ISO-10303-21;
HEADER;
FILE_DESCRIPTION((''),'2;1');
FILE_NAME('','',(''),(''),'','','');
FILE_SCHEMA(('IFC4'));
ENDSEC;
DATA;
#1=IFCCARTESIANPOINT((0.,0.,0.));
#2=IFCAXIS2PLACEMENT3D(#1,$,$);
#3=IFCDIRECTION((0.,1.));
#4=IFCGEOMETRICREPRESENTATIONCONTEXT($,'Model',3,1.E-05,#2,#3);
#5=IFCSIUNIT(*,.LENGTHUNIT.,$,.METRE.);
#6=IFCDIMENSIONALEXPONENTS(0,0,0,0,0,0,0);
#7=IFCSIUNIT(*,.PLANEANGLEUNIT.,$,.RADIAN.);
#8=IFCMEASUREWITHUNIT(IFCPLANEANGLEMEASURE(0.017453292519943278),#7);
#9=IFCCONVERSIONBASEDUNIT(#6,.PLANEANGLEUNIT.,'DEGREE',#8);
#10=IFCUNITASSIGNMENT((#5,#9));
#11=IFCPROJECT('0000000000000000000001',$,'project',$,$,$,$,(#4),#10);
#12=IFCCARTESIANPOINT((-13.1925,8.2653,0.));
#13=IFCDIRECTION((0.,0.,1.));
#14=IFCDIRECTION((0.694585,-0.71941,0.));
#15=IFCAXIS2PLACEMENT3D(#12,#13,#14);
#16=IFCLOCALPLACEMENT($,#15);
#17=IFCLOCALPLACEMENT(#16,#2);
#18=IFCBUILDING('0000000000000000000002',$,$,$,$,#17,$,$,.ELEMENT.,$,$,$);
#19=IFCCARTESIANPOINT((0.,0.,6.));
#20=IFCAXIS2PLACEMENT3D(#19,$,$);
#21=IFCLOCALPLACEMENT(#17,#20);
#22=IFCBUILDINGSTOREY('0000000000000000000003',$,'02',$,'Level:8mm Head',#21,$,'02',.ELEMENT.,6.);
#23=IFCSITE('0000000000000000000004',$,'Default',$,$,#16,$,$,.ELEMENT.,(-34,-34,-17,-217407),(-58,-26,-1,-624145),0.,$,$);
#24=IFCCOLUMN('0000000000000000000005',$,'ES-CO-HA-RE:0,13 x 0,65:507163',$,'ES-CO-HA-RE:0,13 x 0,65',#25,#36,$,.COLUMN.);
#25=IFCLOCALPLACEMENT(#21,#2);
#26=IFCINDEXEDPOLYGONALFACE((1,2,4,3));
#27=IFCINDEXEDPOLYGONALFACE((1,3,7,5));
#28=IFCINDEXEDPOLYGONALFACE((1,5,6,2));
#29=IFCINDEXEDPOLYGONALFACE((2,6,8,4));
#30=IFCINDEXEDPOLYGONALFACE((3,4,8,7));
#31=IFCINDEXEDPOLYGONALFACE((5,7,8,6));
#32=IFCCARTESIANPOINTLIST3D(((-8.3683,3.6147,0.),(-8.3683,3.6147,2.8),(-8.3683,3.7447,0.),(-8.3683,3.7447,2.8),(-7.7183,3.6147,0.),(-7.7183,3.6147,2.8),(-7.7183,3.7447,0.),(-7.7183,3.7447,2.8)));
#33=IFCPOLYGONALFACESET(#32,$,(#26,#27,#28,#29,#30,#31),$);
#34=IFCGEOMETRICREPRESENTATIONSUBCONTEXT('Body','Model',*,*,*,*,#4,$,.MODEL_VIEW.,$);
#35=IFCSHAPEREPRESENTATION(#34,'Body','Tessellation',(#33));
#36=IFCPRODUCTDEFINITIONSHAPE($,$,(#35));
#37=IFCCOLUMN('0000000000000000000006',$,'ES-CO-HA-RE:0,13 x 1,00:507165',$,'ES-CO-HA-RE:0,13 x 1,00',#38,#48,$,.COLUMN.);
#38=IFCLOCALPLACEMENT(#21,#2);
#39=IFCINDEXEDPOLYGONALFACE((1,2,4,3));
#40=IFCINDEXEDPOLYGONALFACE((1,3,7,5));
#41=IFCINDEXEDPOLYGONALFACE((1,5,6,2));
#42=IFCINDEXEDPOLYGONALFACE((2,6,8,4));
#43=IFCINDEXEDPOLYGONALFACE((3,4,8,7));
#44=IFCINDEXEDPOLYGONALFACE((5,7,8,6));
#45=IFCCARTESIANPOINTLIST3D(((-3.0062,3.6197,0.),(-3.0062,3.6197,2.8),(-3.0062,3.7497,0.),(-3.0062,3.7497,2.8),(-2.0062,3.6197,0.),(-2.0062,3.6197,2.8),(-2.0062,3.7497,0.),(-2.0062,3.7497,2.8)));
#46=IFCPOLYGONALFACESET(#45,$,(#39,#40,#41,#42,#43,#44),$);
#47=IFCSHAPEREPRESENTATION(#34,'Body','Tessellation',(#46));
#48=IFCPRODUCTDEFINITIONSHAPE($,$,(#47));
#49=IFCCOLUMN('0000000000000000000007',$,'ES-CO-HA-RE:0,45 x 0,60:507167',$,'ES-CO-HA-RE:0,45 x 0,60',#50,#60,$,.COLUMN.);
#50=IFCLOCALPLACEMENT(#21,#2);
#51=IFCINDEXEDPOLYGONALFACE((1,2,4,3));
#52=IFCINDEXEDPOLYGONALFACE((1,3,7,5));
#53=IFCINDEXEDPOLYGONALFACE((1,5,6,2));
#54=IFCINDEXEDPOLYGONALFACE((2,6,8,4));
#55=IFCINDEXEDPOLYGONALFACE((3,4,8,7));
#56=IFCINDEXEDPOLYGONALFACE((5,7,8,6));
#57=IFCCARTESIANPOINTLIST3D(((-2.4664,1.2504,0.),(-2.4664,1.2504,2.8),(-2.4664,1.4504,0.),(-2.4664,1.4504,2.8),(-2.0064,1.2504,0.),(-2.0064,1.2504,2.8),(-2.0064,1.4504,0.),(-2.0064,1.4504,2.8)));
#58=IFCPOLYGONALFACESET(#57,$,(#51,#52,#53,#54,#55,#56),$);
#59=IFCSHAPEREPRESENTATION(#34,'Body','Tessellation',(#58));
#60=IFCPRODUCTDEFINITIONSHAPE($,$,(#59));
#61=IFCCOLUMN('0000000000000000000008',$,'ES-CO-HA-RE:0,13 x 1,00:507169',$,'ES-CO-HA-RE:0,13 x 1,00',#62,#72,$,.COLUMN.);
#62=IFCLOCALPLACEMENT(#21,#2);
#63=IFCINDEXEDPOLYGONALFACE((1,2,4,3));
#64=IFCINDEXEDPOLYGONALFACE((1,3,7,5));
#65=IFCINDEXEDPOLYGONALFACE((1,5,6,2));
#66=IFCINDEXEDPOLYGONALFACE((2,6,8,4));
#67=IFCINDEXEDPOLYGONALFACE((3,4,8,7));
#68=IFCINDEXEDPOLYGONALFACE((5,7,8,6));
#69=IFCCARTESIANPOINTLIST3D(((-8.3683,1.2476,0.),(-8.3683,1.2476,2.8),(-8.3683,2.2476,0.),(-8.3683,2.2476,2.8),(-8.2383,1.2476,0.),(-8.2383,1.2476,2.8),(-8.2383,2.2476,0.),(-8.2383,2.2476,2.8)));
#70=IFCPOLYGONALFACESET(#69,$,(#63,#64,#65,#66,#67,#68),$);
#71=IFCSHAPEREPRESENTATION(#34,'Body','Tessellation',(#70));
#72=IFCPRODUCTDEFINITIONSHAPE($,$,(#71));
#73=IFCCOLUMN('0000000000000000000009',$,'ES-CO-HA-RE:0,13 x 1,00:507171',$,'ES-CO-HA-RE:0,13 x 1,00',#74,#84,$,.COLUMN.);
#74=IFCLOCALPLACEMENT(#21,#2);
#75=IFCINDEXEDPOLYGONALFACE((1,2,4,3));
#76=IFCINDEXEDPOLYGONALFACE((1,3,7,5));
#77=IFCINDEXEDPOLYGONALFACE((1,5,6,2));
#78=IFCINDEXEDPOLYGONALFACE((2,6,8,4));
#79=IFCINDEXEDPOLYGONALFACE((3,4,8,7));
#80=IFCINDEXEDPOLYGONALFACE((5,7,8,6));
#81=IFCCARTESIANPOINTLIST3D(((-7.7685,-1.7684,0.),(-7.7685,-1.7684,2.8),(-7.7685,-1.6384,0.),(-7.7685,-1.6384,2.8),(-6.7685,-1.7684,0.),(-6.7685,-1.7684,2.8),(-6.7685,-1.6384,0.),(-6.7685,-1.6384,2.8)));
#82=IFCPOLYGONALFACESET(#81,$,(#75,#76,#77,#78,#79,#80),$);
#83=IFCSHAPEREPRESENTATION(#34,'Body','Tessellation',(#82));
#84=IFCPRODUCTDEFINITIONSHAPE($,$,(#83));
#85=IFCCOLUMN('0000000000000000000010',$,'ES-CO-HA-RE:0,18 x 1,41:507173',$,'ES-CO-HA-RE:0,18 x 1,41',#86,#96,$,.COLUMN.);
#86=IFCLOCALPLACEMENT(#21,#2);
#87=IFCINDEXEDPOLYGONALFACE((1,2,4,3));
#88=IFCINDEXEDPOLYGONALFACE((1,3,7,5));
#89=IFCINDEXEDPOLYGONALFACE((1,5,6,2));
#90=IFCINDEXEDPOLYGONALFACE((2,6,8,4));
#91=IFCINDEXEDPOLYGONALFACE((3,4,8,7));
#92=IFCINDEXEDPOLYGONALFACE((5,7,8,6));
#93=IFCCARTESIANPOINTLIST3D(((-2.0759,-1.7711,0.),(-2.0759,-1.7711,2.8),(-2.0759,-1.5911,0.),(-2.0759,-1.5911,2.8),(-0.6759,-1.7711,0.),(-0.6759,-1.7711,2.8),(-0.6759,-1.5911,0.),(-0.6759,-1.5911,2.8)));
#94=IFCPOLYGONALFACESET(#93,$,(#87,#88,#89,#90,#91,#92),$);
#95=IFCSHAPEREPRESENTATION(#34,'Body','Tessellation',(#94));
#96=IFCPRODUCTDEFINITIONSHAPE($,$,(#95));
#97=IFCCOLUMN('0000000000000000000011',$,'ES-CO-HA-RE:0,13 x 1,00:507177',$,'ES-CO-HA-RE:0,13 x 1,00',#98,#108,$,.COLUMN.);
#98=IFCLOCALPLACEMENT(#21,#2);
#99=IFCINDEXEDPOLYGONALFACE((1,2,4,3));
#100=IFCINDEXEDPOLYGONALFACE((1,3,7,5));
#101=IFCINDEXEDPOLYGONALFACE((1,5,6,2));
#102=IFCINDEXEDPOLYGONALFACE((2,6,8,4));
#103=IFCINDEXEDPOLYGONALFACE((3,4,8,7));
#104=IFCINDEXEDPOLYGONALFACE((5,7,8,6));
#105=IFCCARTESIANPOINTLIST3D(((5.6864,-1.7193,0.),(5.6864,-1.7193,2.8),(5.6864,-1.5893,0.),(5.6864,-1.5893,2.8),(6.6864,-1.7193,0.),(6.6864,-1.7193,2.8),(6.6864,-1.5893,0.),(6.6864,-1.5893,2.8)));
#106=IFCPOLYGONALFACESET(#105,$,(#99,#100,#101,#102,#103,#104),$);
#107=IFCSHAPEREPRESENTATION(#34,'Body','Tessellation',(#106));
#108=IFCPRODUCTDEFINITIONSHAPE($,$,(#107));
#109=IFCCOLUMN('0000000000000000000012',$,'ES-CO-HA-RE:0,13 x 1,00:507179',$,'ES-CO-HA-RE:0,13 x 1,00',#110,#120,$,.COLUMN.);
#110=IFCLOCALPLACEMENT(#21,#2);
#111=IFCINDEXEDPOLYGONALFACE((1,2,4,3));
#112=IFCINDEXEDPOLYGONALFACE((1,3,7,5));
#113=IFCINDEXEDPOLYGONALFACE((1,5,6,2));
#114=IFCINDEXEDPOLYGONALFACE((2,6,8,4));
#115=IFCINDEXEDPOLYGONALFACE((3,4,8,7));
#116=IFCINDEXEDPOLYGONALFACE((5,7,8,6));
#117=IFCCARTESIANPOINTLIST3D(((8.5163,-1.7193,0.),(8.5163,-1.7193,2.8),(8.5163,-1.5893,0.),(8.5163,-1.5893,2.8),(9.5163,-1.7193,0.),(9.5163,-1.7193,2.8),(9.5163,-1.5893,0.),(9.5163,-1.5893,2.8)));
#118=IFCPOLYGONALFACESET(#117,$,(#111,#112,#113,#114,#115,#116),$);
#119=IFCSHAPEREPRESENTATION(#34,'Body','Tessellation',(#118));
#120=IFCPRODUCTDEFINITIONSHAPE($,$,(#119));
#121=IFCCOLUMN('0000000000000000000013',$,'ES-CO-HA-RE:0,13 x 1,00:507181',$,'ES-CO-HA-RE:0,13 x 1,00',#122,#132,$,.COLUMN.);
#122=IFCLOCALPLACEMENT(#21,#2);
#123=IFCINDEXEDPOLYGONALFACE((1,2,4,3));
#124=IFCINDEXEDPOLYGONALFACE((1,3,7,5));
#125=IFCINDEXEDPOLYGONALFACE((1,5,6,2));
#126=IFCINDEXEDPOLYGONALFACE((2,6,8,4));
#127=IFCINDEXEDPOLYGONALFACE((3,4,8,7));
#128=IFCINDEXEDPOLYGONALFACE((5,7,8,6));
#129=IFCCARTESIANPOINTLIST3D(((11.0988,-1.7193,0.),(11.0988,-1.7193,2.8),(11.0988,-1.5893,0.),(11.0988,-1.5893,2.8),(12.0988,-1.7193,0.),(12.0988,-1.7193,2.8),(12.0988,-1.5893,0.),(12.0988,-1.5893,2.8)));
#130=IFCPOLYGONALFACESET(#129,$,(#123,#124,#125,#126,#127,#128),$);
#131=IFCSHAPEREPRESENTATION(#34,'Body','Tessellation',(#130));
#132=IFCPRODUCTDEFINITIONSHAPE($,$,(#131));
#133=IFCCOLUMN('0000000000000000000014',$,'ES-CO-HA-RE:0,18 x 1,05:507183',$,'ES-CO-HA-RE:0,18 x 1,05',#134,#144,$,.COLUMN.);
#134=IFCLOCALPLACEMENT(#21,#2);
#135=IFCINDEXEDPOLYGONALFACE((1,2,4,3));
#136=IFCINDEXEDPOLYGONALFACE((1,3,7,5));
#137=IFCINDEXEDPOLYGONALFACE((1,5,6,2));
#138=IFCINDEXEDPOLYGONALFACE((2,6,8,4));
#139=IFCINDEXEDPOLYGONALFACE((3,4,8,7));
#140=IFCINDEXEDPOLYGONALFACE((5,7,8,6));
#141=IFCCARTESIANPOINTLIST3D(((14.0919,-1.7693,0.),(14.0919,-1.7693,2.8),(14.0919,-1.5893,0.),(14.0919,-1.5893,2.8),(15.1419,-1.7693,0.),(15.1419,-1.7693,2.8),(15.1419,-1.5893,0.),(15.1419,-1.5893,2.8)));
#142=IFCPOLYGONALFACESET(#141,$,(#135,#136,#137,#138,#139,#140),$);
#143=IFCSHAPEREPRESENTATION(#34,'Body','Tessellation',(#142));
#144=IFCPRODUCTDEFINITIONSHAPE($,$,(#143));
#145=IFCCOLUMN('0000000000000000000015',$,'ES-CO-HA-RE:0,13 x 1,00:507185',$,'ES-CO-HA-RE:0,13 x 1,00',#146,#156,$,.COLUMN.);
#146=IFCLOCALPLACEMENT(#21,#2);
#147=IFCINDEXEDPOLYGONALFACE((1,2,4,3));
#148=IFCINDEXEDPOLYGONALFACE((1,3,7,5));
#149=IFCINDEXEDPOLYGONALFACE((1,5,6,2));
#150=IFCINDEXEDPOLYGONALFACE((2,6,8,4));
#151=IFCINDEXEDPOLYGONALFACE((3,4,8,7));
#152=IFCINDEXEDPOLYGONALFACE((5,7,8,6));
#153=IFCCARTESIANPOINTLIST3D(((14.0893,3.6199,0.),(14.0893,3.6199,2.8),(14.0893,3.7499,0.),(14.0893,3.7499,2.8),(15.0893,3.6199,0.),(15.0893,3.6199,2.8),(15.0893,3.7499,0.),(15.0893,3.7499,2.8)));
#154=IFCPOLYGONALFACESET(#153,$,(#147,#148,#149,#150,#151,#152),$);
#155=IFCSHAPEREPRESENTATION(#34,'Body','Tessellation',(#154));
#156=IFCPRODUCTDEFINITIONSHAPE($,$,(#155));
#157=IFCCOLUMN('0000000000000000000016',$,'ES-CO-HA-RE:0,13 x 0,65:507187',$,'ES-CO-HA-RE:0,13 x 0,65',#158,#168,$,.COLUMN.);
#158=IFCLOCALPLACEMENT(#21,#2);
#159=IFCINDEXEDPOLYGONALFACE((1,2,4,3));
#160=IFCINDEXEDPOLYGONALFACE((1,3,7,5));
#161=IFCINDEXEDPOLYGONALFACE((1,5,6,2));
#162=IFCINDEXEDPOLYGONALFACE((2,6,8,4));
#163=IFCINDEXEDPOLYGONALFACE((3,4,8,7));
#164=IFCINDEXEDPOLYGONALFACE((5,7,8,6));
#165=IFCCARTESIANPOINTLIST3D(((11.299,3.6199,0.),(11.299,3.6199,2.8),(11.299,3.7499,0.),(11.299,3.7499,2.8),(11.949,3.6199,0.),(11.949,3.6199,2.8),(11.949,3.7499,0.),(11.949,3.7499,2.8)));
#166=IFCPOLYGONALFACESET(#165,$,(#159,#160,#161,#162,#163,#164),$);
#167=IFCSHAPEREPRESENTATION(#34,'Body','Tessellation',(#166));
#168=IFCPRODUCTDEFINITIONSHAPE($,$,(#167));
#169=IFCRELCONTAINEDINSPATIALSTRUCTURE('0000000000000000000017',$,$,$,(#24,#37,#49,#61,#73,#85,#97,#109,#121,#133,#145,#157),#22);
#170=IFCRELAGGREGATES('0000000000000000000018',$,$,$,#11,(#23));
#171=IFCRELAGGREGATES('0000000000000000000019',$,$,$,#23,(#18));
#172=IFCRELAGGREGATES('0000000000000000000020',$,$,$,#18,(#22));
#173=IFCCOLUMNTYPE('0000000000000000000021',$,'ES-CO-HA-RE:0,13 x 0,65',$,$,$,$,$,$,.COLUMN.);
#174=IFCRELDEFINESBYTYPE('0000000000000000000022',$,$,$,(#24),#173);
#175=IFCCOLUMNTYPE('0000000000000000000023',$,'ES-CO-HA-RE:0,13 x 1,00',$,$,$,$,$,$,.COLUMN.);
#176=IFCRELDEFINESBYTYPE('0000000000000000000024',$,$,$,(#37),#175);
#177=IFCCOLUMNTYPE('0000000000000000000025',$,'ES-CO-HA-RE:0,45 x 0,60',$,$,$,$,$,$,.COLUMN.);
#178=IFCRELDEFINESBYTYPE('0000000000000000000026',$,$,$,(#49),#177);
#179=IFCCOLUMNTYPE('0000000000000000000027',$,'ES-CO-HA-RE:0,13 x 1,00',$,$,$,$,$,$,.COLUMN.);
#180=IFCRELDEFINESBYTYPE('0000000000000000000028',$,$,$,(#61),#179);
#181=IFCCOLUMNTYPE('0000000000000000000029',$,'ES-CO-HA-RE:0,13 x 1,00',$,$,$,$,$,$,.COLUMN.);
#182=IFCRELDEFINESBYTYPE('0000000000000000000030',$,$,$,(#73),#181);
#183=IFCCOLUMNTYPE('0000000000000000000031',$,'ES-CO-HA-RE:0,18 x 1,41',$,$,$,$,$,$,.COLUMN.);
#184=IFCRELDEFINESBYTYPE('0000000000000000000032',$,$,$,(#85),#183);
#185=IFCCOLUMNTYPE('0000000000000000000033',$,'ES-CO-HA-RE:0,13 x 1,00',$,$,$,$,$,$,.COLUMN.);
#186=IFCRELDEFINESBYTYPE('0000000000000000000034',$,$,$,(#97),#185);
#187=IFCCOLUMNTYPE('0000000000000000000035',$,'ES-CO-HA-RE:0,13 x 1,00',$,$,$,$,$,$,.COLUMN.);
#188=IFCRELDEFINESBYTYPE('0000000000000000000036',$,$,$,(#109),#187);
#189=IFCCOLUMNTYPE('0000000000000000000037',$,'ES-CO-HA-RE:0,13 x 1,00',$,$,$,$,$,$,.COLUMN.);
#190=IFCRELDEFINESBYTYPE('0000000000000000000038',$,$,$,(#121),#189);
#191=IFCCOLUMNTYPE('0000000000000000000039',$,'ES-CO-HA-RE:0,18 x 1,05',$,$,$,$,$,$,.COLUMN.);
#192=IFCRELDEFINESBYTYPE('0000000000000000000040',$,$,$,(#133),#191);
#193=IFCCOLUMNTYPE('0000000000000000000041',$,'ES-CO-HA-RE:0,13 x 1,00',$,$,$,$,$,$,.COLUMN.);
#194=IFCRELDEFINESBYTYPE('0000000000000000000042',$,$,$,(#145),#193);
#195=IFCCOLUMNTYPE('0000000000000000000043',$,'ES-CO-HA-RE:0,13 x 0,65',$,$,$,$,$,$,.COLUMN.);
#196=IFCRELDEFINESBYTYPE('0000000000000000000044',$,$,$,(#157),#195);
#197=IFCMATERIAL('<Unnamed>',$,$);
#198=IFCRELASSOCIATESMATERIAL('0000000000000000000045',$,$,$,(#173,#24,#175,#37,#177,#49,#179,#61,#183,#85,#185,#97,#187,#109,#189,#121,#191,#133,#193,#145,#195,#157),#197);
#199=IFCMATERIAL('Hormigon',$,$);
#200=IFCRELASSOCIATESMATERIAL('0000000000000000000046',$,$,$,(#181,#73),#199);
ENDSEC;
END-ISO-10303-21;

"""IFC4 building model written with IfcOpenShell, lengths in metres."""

from ifc_helpers import new_model, entity, si_unit, converted_unit, direction, frame, origin, place, context, subcontext, project, spatial, indexed_curve, outline, extrude, source, transform, mapped, material, type_object, type_shapes, element, save


model = new_model("IFC4")

# Units and contexts
model_context = context("Model", 3, precision=1e-05, world=origin(), true_north=direction((0.0, 1.0)))
body_context = subcontext(model_context, "Body", "Model", "MODEL_VIEW")
ifc_project = project(units=[si_unit("LENGTHUNIT", "METRE"), converted_unit("PLANEANGLEUNIT", "DEGREE", entity("IfcPlaneAngleMeasure", 0.017453292519943278), si_unit("PLANEANGLEUNIT", "RADIAN"), dimensions=[0, 0, 0, 0, 0, 0, 0])], contexts=[model_context])

# Site, building, storey
site_placement = place(None, frame((-13.1925, 8.2653, 0.0), z_axis=(0.0, 0.0, 1.0), x_axis=(0.694585, -0.71941, 0.0)))
site = spatial("IfcSite", under=ifc_project, at=site_placement, Name="Default", CompositionType="ELEMENT", RefLatitude=(-34, -34, -17, -217407), RefLongitude=(-58, -26, -1, -624145), RefElevation=0.0)
building_placement = place(site_placement, origin())
building = spatial("IfcBuilding", under=site, at=building_placement, CompositionType="ELEMENT")
storey_placement = place(building_placement, frame((0.0, 0.0, 6.0)))
storey = spatial("IfcBuildingStorey", under=building, at=storey_placement, Name="02", ObjectType="Level:8mm Head", LongName="02", CompositionType="ELEMENT", Elevation=6.0)

# Columns
ifc_material_1 = material(Name="<Unnamed>")
column_type_1 = type_object("IfcColumnType", Name="ES-CO-HA-RE:0,13 x 0,65", PredefinedType="COLUMN", material=ifc_material_1)
shared_shape_1 = source(origin(), body_context, "Body", "SweptSolid", [
    extrude(outline(indexed_curve([(-0.325, -0.065), (0.325, -0.065), (0.325, 0.065), (-0.325, 0.065), (-0.325, -0.065)], self_intersect=False)), frame((-8.0433, 3.6797, 6.0), z_axis=(0.0, 0.0, 1.0), x_axis=(-1.0, 0.0, 0.0)), (0.0, 0.0, 1.0), 2.8),
])
type_shapes(column_type_1, [shared_shape_1])
column_1_placement = place(storey_placement, frame((0.0, 0.0, -6.0)))
element("IfcColumn", 1, at=column_1_placement, inside=storey, type_object=column_type_1, material=ifc_material_1, Name="ES-CO-HA-RE:0,13 x 0,65:507163", ObjectType="ES-CO-HA-RE:0,13 x 0,65", PredefinedType="COLUMN", context=body_context, shape_type="MappedRepresentation", body=[
    mapped(shared_shape_1, transform((0.0, 0.0, 0.0), scale=1.0)),
])
column_type_2 = type_object("IfcColumnType", Name="ES-CO-HA-RE:0,13 x 1,00", PredefinedType="COLUMN", material=ifc_material_1)
shared_shape_2 = source(origin(), body_context, "Body", "SweptSolid", [
    extrude(outline(indexed_curve([(-0.5, -0.065), (0.5, -0.065), (0.5, 0.065), (-0.5, 0.065), (-0.5, -0.065)], self_intersect=False)), frame((-2.5062, 3.6847, 6.0), z_axis=(0.0, 0.0, 1.0), x_axis=(-1.0, 0.0, 0.0)), (0.0, 0.0, 1.0), 2.8),
])
type_shapes(column_type_2, [shared_shape_2])
column_2_placement = place(storey_placement, frame((0.0, 0.0, -6.0)))
element("IfcColumn", 2, at=column_2_placement, inside=storey, type_object=column_type_2, material=ifc_material_1, Name="ES-CO-HA-RE:0,13 x 1,00:507165", ObjectType="ES-CO-HA-RE:0,13 x 1,00", PredefinedType="COLUMN", context=body_context, shape_type="MappedRepresentation", body=[
    mapped(shared_shape_2, transform((0.0, 0.0, 0.0), scale=1.0)),
])
column_type_3 = type_object("IfcColumnType", Name="ES-CO-HA-RE:0,45 x 0,60", PredefinedType="COLUMN", material=ifc_material_1)
shared_shape_3 = source(origin(), body_context, "Body", "SweptSolid", [
    extrude(outline(indexed_curve([(-0.23, -0.1), (0.23, -0.1), (0.23, 0.1), (-0.23, 0.1), (-0.23, -0.1)], self_intersect=False)), frame((-2.2364, 1.3504, 6.0), z_axis=(0.0, 0.0, 1.0), x_axis=(-1.0, 0.0, 0.0)), (0.0, 0.0, 1.0), 2.8),
])
type_shapes(column_type_3, [shared_shape_3])
column_3_placement = place(storey_placement, frame((0.0, 0.0, -6.0)))
element("IfcColumn", 3, at=column_3_placement, inside=storey, type_object=column_type_3, material=ifc_material_1, Name="ES-CO-HA-RE:0,45 x 0,60:507167", ObjectType="ES-CO-HA-RE:0,45 x 0,60", PredefinedType="COLUMN", context=body_context, shape_type="MappedRepresentation", body=[
    mapped(shared_shape_3, transform((0.0, 0.0, 0.0), scale=1.0)),
])
column_type_4 = type_object("IfcColumnType", Name="ES-CO-HA-RE:0,13 x 1,00", PredefinedType="COLUMN", material=ifc_material_1)
shared_shape_4 = source(origin(), body_context, "Body", "SweptSolid", [
    extrude(outline(indexed_curve([(-0.5, -0.065), (0.5, -0.065), (0.5, 0.065), (-0.5, 0.065), (-0.5, -0.065)], self_intersect=False)), frame((-8.3033, 1.7476, 6.0), z_axis=(0.0, 0.0, 1.0), x_axis=(0.0, -1.0, 0.0)), (0.0, 0.0, 1.0), 2.8),
])
type_shapes(column_type_4, [shared_shape_4])
column_4_placement = place(storey_placement, frame((0.0, 0.0, -6.0)))
element("IfcColumn", 4, at=column_4_placement, inside=storey, type_object=column_type_4, material=ifc_material_1, Name="ES-CO-HA-RE:0,13 x 1,00:507169", ObjectType="ES-CO-HA-RE:0,13 x 1,00", PredefinedType="COLUMN", context=body_context, shape_type="MappedRepresentation", body=[
    mapped(shared_shape_4, transform((0.0, 0.0, 0.0), scale=1.0)),
])
ifc_material_2 = material(Name="Hormigon")
column_type_5 = type_object("IfcColumnType", Name="ES-CO-HA-RE:0,13 x 1,00", PredefinedType="COLUMN", material=ifc_material_2)
shared_shape_5 = source(origin(), body_context, "Body", "SweptSolid", [
    extrude(outline(indexed_curve([(-0.5, -0.065), (0.5, -0.065), (0.5, 0.065), (-0.5, 0.065), (-0.5, -0.065)], self_intersect=False)), frame((-7.2685, -1.7034, 6.0), z_axis=(0.0, 0.0, 1.0), x_axis=(-1.0, 0.0, 0.0)), (0.0, 0.0, 1.0), 2.8),
])
type_shapes(column_type_5, [shared_shape_5])
column_5_placement = place(storey_placement, frame((0.0, 0.0, -6.0)))
element("IfcColumn", 5, at=column_5_placement, inside=storey, type_object=column_type_5, material=ifc_material_2, Name="ES-CO-HA-RE:0,13 x 1,00:507171", ObjectType="ES-CO-HA-RE:0,13 x 1,00", PredefinedType="COLUMN", context=body_context, shape_type="MappedRepresentation", body=[
    mapped(shared_shape_5, transform((0.0, 0.0, 0.0), scale=1.0)),
])
column_type_6 = type_object("IfcColumnType", Name="ES-CO-HA-RE:0,18 x 1,41", PredefinedType="COLUMN", material=ifc_material_1)
shared_shape_6 = source(origin(), body_context, "Body", "SweptSolid", [
    extrude(outline(indexed_curve([(-0.7, -0.09), (0.7, -0.09), (0.7, 0.09), (-0.7, 0.09), (-0.7, -0.09)], self_intersect=False)), frame((-1.3759, -1.6811, 6.0), z_axis=(0.0, 0.0, 1.0), x_axis=(-1.0, 0.0, 0.0)), (0.0, 0.0, 1.0), 2.8),
])
type_shapes(column_type_6, [shared_shape_6])
column_6_placement = place(storey_placement, frame((0.0, 0.0, -6.0)))
element("IfcColumn", 6, at=column_6_placement, inside=storey, type_object=column_type_6, material=ifc_material_1, Name="ES-CO-HA-RE:0,18 x 1,41:507173", ObjectType="ES-CO-HA-RE:0,18 x 1,41", PredefinedType="COLUMN", context=body_context, shape_type="MappedRepresentation", body=[
    mapped(shared_shape_6, transform((0.0, 0.0, 0.0), scale=1.0)),
])
column_type_7 = type_object("IfcColumnType", Name="ES-CO-HA-RE:0,13 x 1,00", PredefinedType="COLUMN", material=ifc_material_1)
shared_shape_7 = source(origin(), body_context, "Body", "SweptSolid", [
    extrude(outline(indexed_curve([(-0.5, -0.065), (0.5, -0.065), (0.5, 0.065), (-0.5, 0.065), (-0.5, -0.065)], self_intersect=False)), frame((6.1864, -1.6543, 6.0), z_axis=(0.0, 0.0, 1.0), x_axis=(-1.0, 0.0, 0.0)), (0.0, 0.0, 1.0), 2.8),
])
type_shapes(column_type_7, [shared_shape_7])
column_7_placement = place(storey_placement, frame((0.0, 0.0, -6.0)))
element("IfcColumn", 7, at=column_7_placement, inside=storey, type_object=column_type_7, material=ifc_material_1, Name="ES-CO-HA-RE:0,13 x 1,00:507177", ObjectType="ES-CO-HA-RE:0,13 x 1,00", PredefinedType="COLUMN", context=body_context, shape_type="MappedRepresentation", body=[
    mapped(shared_shape_7, transform((0.0, 0.0, 0.0), scale=1.0)),
])
column_type_8 = type_object("IfcColumnType", Name="ES-CO-HA-RE:0,13 x 1,00", PredefinedType="COLUMN", material=ifc_material_1)
shared_shape_8 = source(origin(), body_context, "Body", "SweptSolid", [
    extrude(outline(indexed_curve([(-0.5, -0.065), (0.5, -0.065), (0.5, 0.065), (-0.5, 0.065), (-0.5, -0.065)], self_intersect=False)), frame((9.0163, -1.6543, 6.0), z_axis=(0.0, 0.0, 1.0), x_axis=(-1.0, 0.0, 0.0)), (0.0, 0.0, 1.0), 2.8),
])
type_shapes(column_type_8, [shared_shape_8])
column_8_placement = place(storey_placement, frame((0.0, 0.0, -6.0)))
element("IfcColumn", 8, at=column_8_placement, inside=storey, type_object=column_type_8, material=ifc_material_1, Name="ES-CO-HA-RE:0,13 x 1,00:507179", ObjectType="ES-CO-HA-RE:0,13 x 1,00", PredefinedType="COLUMN", context=body_context, shape_type="MappedRepresentation", body=[
    mapped(shared_shape_8, transform((0.0, 0.0, 0.0), scale=1.0)),
])
column_type_9 = type_object("IfcColumnType", Name="ES-CO-HA-RE:0,13 x 1,00", PredefinedType="COLUMN", material=ifc_material_1)
shared_shape_9 = source(origin(), body_context, "Body", "SweptSolid", [
    extrude(outline(indexed_curve([(-0.5, -0.065), (0.5, -0.065), (0.5, 0.065), (-0.5, 0.065), (-0.5, -0.065)], self_intersect=False)), frame((11.5988, -1.6543, 6.0), z_axis=(0.0, 0.0, 1.0), x_axis=(-1.0, 0.0, 0.0)), (0.0, 0.0, 1.0), 2.8),
])
type_shapes(column_type_9, [shared_shape_9])
column_9_placement = place(storey_placement, frame((0.0, 0.0, -6.0)))
element("IfcColumn", 9, at=column_9_placement, inside=storey, type_object=column_type_9, material=ifc_material_1, Name="ES-CO-HA-RE:0,13 x 1,00:507181", ObjectType="ES-CO-HA-RE:0,13 x 1,00", PredefinedType="COLUMN", context=body_context, shape_type="MappedRepresentation", body=[
    mapped(shared_shape_9, transform((0.0, 0.0, 0.0), scale=1.0)),
])
column_type_10 = type_object("IfcColumnType", Name="ES-CO-HA-RE:0,18 x 1,05", PredefinedType="COLUMN", material=ifc_material_1)
shared_shape_10 = source(origin(), body_context, "Body", "SweptSolid", [
    extrude(outline(indexed_curve([(-0.525, -0.09), (0.525, -0.09), (0.525, 0.09), (-0.525, 0.09), (-0.525, -0.09)], self_intersect=False)), frame((14.6169, -1.6793, 6.0), z_axis=(0.0, 0.0, 1.0), x_axis=(-1.0, 0.0, 0.0)), (0.0, 0.0, 1.0), 2.8),
])
type_shapes(column_type_10, [shared_shape_10])
column_10_placement = place(storey_placement, frame((0.0, 0.0, -6.0)))
element("IfcColumn", 10, at=column_10_placement, inside=storey, type_object=column_type_10, material=ifc_material_1, Name="ES-CO-HA-RE:0,18 x 1,05:507183", ObjectType="ES-CO-HA-RE:0,18 x 1,05", PredefinedType="COLUMN", context=body_context, shape_type="MappedRepresentation", body=[
    mapped(shared_shape_10, transform((0.0, 0.0, 0.0), scale=1.0)),
])
column_type_11 = type_object("IfcColumnType", Name="ES-CO-HA-RE:0,13 x 1,00", PredefinedType="COLUMN", material=ifc_material_1)
shared_shape_11 = source(origin(), body_context, "Body", "SweptSolid", [
    extrude(outline(indexed_curve([(-0.5, -0.065), (0.5, -0.065), (0.5, 0.065), (-0.5, 0.065), (-0.5, -0.065)], self_intersect=False)), frame((14.5893, 3.6849, 6.0), z_axis=(0.0, 0.0, 1.0), x_axis=(-1.0, 0.0, 0.0)), (0.0, 0.0, 1.0), 2.8),
])
type_shapes(column_type_11, [shared_shape_11])
column_11_placement = place(storey_placement, frame((0.0, 0.0, -6.0)))
element("IfcColumn", 11, at=column_11_placement, inside=storey, type_object=column_type_11, material=ifc_material_1, Name="ES-CO-HA-RE:0,13 x 1,00:507185", ObjectType="ES-CO-HA-RE:0,13 x 1,00", PredefinedType="COLUMN", context=body_context, shape_type="MappedRepresentation", body=[
    mapped(shared_shape_11, transform((0.0, 0.0, 0.0), scale=1.0)),
])
column_type_12 = type_object("IfcColumnType", Name="ES-CO-HA-RE:0,13 x 0,65", PredefinedType="COLUMN", material=ifc_material_1)
shared_shape_12 = source(origin(), body_context, "Body", "SweptSolid", [
    extrude(outline(indexed_curve([(-0.325, -0.065), (0.325, -0.065), (0.325, 0.065), (-0.325, 0.065), (-0.325, -0.065)], self_intersect=False)), frame((11.624, 3.6849, 6.0), z_axis=(0.0, 0.0, 1.0), x_axis=(-1.0, 0.0, 0.0)), (0.0, 0.0, 1.0), 2.8),
])
type_shapes(column_type_12, [shared_shape_12])
column_12_placement = place(storey_placement, frame((0.0, 0.0, -6.0)))
element("IfcColumn", 12, at=column_12_placement, inside=storey, type_object=column_type_12, material=ifc_material_1, Name="ES-CO-HA-RE:0,13 x 0,65:507187", ObjectType="ES-CO-HA-RE:0,13 x 0,65", PredefinedType="COLUMN", context=body_context, shape_type="MappedRepresentation", body=[
    mapped(shared_shape_12, transform((0.0, 0.0, 0.0), scale=1.0)),
])

save(model, "model.ifc")
